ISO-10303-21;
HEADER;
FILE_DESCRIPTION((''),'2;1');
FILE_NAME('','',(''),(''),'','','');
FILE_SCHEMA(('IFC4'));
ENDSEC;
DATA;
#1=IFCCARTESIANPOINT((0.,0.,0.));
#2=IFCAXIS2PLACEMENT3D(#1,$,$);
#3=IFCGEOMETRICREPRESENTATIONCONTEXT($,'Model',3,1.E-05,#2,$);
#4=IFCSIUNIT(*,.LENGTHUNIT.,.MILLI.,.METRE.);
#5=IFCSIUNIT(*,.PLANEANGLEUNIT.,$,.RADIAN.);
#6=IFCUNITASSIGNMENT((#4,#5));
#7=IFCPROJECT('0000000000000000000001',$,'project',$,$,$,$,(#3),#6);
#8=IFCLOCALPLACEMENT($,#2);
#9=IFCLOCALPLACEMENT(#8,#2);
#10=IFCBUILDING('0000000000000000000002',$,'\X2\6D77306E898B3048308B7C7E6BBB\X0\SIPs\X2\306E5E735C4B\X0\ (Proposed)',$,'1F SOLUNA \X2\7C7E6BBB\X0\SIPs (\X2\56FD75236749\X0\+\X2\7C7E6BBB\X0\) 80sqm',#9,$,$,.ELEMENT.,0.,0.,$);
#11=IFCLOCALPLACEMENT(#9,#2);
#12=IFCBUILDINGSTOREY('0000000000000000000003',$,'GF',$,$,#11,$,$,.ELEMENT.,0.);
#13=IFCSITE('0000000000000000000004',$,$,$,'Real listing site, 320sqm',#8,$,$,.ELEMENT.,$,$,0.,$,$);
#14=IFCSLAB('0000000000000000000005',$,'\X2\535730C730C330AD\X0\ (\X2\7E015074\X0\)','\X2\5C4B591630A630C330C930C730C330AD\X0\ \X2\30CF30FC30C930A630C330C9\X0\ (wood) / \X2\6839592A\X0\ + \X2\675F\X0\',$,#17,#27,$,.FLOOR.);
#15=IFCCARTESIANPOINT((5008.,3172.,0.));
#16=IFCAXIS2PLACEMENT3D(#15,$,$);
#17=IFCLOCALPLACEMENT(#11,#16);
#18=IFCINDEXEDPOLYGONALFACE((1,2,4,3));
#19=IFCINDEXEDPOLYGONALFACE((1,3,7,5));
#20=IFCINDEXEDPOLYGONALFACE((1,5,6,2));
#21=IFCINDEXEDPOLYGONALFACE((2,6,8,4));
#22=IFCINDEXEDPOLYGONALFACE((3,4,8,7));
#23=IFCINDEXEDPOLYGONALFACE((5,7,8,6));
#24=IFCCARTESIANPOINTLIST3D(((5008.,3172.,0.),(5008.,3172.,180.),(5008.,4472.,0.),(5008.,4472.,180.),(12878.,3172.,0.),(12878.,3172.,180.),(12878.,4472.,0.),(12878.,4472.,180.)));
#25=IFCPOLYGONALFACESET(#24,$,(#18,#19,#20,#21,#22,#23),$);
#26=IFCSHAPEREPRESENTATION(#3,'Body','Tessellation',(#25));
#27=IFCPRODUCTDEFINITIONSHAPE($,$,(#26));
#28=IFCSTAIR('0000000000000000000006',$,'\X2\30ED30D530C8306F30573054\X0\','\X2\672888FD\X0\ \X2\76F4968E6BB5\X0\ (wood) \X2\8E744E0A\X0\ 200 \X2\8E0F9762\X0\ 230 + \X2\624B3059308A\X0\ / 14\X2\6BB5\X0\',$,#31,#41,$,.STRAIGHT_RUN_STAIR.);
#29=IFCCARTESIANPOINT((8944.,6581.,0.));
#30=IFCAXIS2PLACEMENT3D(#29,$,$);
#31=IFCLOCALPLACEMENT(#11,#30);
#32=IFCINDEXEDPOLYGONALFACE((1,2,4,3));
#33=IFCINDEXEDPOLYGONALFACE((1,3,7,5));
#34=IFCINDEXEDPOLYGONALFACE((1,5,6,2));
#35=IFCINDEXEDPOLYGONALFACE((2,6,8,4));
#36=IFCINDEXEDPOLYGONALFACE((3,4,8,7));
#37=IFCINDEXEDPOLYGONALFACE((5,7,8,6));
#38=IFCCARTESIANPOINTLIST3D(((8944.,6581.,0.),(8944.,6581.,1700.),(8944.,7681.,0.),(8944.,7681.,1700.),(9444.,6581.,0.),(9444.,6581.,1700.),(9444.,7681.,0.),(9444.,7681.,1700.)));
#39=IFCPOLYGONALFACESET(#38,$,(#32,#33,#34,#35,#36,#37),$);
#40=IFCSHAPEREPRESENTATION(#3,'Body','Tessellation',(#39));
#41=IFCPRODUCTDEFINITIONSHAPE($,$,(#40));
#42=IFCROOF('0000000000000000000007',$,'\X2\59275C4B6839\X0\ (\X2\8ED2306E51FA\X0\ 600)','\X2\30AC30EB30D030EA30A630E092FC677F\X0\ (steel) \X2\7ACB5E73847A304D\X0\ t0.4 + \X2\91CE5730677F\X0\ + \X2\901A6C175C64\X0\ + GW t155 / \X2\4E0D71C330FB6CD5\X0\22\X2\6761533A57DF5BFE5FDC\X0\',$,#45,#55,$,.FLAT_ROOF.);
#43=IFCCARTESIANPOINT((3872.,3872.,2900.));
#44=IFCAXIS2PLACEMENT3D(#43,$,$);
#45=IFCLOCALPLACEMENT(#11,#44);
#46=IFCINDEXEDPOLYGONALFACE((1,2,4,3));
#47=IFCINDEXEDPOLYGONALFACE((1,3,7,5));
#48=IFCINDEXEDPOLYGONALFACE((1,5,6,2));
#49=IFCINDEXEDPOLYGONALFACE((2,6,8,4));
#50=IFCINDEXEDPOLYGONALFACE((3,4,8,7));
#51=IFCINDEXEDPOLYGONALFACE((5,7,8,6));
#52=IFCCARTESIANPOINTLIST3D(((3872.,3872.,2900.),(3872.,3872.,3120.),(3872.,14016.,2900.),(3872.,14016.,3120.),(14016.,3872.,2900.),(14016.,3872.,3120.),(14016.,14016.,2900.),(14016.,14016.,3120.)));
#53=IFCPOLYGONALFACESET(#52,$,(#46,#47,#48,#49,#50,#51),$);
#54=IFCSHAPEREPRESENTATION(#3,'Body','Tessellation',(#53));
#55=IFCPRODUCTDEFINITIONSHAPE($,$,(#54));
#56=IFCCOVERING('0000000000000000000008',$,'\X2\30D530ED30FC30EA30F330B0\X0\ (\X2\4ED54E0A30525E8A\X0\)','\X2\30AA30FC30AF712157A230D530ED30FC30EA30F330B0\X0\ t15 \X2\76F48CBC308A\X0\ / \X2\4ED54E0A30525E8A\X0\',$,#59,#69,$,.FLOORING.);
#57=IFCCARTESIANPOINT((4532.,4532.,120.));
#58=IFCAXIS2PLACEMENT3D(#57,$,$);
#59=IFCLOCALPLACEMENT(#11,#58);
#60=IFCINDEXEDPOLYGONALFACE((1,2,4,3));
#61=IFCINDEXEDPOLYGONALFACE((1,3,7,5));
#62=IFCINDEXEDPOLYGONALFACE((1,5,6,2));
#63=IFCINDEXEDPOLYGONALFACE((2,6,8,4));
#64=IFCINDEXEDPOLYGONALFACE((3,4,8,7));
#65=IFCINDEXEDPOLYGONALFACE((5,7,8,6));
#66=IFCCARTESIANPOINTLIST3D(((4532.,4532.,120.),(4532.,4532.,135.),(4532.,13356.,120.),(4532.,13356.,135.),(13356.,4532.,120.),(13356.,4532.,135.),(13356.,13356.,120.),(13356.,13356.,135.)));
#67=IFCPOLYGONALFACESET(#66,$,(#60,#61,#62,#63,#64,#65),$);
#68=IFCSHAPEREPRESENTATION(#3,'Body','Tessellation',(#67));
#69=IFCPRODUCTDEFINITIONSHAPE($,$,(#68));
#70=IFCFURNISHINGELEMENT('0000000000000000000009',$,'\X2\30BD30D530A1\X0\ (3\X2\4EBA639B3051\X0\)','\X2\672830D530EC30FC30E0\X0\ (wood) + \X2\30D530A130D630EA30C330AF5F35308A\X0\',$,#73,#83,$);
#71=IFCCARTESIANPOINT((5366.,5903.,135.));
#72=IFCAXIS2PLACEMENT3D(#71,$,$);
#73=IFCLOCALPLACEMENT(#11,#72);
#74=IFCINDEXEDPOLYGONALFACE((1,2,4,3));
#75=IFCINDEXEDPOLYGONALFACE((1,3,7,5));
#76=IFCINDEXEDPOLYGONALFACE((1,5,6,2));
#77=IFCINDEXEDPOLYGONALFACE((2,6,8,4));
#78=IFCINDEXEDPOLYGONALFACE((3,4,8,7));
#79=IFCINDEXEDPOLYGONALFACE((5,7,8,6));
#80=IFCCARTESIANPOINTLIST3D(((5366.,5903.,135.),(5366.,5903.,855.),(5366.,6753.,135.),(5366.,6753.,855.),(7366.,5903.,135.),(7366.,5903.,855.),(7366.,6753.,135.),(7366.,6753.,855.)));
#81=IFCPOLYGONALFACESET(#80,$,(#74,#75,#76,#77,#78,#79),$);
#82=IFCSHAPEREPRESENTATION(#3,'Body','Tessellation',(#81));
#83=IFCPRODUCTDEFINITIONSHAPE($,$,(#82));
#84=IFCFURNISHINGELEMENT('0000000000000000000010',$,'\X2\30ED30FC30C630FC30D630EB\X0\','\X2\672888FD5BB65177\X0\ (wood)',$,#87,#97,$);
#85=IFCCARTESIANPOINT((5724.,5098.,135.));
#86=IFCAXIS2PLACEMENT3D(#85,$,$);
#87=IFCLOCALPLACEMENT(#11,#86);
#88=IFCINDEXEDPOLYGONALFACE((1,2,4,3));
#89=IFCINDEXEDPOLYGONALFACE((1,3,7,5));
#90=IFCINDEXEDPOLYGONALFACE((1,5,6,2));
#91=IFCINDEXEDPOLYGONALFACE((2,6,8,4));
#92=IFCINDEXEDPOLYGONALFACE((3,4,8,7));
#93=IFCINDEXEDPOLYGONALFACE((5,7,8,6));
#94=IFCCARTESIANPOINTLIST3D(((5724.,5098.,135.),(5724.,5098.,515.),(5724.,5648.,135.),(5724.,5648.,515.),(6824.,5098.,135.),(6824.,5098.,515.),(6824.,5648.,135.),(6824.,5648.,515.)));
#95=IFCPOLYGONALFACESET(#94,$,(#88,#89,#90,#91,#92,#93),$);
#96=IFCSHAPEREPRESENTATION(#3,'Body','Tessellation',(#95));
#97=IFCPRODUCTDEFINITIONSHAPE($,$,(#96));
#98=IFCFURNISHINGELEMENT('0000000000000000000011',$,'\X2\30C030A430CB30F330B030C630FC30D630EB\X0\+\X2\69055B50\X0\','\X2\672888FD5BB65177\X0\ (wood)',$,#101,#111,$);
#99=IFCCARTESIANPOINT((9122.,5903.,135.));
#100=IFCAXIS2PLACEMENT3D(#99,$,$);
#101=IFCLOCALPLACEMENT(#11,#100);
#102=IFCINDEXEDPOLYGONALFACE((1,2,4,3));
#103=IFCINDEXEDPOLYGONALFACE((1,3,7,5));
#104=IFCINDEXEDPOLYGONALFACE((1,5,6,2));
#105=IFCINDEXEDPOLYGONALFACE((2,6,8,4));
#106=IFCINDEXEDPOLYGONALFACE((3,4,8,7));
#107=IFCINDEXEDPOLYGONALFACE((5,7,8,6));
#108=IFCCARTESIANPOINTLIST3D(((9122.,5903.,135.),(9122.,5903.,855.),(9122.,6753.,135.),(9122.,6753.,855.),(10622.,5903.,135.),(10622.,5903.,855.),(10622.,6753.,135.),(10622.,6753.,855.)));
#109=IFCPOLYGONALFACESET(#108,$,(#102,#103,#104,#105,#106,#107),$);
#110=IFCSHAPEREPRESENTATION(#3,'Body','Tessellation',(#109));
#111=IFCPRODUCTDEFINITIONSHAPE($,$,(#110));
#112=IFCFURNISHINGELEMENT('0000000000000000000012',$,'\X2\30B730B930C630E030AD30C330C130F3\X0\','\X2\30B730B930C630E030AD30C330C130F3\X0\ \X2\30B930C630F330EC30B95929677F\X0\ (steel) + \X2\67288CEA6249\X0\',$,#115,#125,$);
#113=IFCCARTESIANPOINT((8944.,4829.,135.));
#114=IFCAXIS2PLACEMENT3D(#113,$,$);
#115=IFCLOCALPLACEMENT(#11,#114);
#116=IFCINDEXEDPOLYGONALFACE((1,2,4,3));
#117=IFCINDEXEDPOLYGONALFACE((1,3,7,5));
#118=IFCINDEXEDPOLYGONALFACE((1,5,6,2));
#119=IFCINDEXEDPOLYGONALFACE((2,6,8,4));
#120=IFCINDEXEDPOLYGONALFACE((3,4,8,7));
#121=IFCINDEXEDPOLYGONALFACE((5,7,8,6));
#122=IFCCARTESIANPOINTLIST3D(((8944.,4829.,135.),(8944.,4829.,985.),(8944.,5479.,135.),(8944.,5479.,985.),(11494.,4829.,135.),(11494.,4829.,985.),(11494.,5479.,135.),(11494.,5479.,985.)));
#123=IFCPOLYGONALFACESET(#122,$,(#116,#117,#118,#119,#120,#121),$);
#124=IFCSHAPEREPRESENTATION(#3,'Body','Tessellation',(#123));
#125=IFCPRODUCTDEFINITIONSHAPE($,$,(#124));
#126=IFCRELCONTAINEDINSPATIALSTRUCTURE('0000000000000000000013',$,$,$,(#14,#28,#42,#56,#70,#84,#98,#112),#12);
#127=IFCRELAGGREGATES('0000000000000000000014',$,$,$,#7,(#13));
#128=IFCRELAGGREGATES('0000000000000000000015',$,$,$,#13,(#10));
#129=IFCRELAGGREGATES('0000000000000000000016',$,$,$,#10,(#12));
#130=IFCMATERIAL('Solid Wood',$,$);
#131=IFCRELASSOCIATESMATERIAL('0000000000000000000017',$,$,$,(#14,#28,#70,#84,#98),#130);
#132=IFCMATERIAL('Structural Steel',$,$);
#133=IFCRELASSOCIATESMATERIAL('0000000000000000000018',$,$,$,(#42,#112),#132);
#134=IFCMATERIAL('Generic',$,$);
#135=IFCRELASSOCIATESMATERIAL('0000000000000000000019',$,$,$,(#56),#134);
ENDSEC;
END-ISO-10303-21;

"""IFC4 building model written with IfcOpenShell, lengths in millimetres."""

from ifc_helpers import new_model, si_unit, frame, frame_2d, origin, place, context, project, spatial, rectangle, extrude, material, element, save


model = new_model("IFC4")

# Units and contexts
model_context = context("Model", 3, precision=1e-05, world=origin())
ifc_project = project(units=[si_unit("LENGTHUNIT", "METRE", prefix="MILLI"), si_unit("PLANEANGLEUNIT", "RADIAN")], contexts=[model_context])

# Site, building, storey
site_placement = place(None, origin())
site = spatial("IfcSite", under=ifc_project, at=site_placement, ObjectType="Real listing site, 320sqm", CompositionType="ELEMENT", RefElevation=0.0)
building_placement = place(site_placement, origin())
building = spatial("IfcBuilding", under=site, at=building_placement, Name="海の見える籾殻SIPsの平屋 (Proposed)", ObjectType="1F SOLUNA 籾殻SIPs (国産杉+籾殻) 80sqm", CompositionType="ELEMENT", ElevationOfRefHeight=0.0, ElevationOfTerrain=0.0)
storey_placement = place(building_placement, origin())
storey = spatial("IfcBuildingStorey", under=building, at=storey_placement, Name="GF", CompositionType="ELEMENT", Elevation=0.0)

# Slab
ifc_material_1 = material(Name="Solid Wood")
slab_1_placement = place(storey_placement, frame((5008.0, 3172.0, 0.0)))
element("IfcSlab", 1, at=slab_1_placement, inside=storey, material=ifc_material_1, Name="南デッキ (縁側)", Description="屋外ウッドデッキ ハードウッド (wood) / 根太 + 束", PredefinedType="FLOOR", context=model_context, shape_type="SweptSolid", body=[
    extrude(rectangle(XDim=7870.0, YDim=1300.0, at=frame_2d((3935.0, 650.0))), frame((5008.0, 3172.0, 0.0)), (0.0, 0.0, 1.0), 180.0),
])

# Stair
stair_placement = place(storey_placement, frame((8944.0, 6581.0, 0.0)))
element("IfcStair", 2, at=stair_placement, inside=storey, material=ifc_material_1, Name="ロフトはしご", Description="木製 直階段 (wood) 蹴上 200 踏面 230 + 手すり / 14段", PredefinedType="STRAIGHT_RUN_STAIR", context=model_context, shape_type="SweptSolid", body=[
    extrude(rectangle(XDim=500.0, YDim=1100.0, at=frame_2d((250.0, 550.0))), frame((8944.0, 6581.0, 0.0)), (0.0, 0.0, 1.0), 1700.0),
])

# Roof
ifc_material_2 = material(Name="Structural Steel")
roof_placement = place(storey_placement, frame((3872.0, 3872.0, 2900.0)))
element("IfcRoof", 3, at=roof_placement, inside=storey, material=ifc_material_2, Name="大屋根 (軒の出 600)", Description="ガルバリウム鋼板 (steel) 立平葺き t0.4 + 野地板 + 通気層 + GW t155 / 不燃・法22条区域対応", PredefinedType="FLAT_ROOF", context=model_context, shape_type="SweptSolid", body=[
    extrude(rectangle(XDim=10144.0, YDim=10144.0, at=frame_2d((5072.0, 5072.0))), frame((3872.0, 3872.0, 2900.0)), (0.0, 0.0, 1.0), 220.0),
])

# Covering
ifc_material_3 = material(Name="Generic")
covering_placement = place(storey_placement, frame((4532.0, 4532.0, 120.0)))
element("IfcCovering", 4, at=covering_placement, inside=storey, material=ifc_material_3, Name="フローリング (仕上げ床)", Description="オーク無垢フローリング t15 直貼り / 仕上げ床", PredefinedType="FLOORING", context=model_context, shape_type="SweptSolid", body=[
    extrude(rectangle(XDim=8824.0, YDim=8824.0, at=frame_2d((4412.0, 4412.0))), frame((4532.0, 4532.0, 120.0)), (0.0, 0.0, 1.0), 15.0),
])

# Furnishing elements
furnishing_1_placement = place(storey_placement, frame((5366.0, 5903.0, 135.0)))
element("IfcFurnishingElement", 5, at=furnishing_1_placement, inside=storey, material=ifc_material_1, Name="ソファ (3人掛け)", Description="木フレーム (wood) + ファブリック張り", context=model_context, shape_type="SweptSolid", body=[
    extrude(rectangle(XDim=2000.0, YDim=850.0, at=frame_2d((1000.0, 425.0))), frame((5366.0, 5903.0, 135.0)), (0.0, 0.0, 1.0), 720.0),
])
furnishing_2_placement = place(storey_placement, frame((5724.0, 5098.0, 135.0)))
element("IfcFurnishingElement", 6, at=furnishing_2_placement, inside=storey, material=ifc_material_1, Name="ローテーブル", Description="木製家具 (wood)", context=model_context, shape_type="SweptSolid", body=[
    extrude(rectangle(XDim=1100.0, YDim=550.0, at=frame_2d((550.0, 275.0))), frame((5724.0, 5098.0, 135.0)), (0.0, 0.0, 1.0), 380.0),
])
furnishing_3_placement = place(storey_placement, frame((9122.0, 5903.0, 135.0)))
element("IfcFurnishingElement", 7, at=furnishing_3_placement, inside=storey, material=ifc_material_1, Name="ダイニングテーブル+椅子", Description="木製家具 (wood)", context=model_context, shape_type="SweptSolid", body=[
    extrude(rectangle(XDim=1500.0, YDim=850.0, at=frame_2d((750.0, 425.0))), frame((9122.0, 5903.0, 135.0)), (0.0, 0.0, 1.0), 720.0),
])
furnishing_4_placement = place(storey_placement, frame((8944.0, 4829.0, 135.0)))
element("IfcFurnishingElement", 8, at=furnishing_4_placement, inside=storey, material=ifc_material_2, Name="システムキッチン", Description="システムキッチン ステンレス天板 (steel) + 木質扉", context=model_context, shape_type="SweptSolid", body=[
    extrude(rectangle(XDim=2550.0, YDim=650.0, at=frame_2d((1275.0, 325.0))), frame((8944.0, 4829.0, 135.0)), (0.0, 0.0, 1.0), 850.0),
])

save(model, "model.ifc")
